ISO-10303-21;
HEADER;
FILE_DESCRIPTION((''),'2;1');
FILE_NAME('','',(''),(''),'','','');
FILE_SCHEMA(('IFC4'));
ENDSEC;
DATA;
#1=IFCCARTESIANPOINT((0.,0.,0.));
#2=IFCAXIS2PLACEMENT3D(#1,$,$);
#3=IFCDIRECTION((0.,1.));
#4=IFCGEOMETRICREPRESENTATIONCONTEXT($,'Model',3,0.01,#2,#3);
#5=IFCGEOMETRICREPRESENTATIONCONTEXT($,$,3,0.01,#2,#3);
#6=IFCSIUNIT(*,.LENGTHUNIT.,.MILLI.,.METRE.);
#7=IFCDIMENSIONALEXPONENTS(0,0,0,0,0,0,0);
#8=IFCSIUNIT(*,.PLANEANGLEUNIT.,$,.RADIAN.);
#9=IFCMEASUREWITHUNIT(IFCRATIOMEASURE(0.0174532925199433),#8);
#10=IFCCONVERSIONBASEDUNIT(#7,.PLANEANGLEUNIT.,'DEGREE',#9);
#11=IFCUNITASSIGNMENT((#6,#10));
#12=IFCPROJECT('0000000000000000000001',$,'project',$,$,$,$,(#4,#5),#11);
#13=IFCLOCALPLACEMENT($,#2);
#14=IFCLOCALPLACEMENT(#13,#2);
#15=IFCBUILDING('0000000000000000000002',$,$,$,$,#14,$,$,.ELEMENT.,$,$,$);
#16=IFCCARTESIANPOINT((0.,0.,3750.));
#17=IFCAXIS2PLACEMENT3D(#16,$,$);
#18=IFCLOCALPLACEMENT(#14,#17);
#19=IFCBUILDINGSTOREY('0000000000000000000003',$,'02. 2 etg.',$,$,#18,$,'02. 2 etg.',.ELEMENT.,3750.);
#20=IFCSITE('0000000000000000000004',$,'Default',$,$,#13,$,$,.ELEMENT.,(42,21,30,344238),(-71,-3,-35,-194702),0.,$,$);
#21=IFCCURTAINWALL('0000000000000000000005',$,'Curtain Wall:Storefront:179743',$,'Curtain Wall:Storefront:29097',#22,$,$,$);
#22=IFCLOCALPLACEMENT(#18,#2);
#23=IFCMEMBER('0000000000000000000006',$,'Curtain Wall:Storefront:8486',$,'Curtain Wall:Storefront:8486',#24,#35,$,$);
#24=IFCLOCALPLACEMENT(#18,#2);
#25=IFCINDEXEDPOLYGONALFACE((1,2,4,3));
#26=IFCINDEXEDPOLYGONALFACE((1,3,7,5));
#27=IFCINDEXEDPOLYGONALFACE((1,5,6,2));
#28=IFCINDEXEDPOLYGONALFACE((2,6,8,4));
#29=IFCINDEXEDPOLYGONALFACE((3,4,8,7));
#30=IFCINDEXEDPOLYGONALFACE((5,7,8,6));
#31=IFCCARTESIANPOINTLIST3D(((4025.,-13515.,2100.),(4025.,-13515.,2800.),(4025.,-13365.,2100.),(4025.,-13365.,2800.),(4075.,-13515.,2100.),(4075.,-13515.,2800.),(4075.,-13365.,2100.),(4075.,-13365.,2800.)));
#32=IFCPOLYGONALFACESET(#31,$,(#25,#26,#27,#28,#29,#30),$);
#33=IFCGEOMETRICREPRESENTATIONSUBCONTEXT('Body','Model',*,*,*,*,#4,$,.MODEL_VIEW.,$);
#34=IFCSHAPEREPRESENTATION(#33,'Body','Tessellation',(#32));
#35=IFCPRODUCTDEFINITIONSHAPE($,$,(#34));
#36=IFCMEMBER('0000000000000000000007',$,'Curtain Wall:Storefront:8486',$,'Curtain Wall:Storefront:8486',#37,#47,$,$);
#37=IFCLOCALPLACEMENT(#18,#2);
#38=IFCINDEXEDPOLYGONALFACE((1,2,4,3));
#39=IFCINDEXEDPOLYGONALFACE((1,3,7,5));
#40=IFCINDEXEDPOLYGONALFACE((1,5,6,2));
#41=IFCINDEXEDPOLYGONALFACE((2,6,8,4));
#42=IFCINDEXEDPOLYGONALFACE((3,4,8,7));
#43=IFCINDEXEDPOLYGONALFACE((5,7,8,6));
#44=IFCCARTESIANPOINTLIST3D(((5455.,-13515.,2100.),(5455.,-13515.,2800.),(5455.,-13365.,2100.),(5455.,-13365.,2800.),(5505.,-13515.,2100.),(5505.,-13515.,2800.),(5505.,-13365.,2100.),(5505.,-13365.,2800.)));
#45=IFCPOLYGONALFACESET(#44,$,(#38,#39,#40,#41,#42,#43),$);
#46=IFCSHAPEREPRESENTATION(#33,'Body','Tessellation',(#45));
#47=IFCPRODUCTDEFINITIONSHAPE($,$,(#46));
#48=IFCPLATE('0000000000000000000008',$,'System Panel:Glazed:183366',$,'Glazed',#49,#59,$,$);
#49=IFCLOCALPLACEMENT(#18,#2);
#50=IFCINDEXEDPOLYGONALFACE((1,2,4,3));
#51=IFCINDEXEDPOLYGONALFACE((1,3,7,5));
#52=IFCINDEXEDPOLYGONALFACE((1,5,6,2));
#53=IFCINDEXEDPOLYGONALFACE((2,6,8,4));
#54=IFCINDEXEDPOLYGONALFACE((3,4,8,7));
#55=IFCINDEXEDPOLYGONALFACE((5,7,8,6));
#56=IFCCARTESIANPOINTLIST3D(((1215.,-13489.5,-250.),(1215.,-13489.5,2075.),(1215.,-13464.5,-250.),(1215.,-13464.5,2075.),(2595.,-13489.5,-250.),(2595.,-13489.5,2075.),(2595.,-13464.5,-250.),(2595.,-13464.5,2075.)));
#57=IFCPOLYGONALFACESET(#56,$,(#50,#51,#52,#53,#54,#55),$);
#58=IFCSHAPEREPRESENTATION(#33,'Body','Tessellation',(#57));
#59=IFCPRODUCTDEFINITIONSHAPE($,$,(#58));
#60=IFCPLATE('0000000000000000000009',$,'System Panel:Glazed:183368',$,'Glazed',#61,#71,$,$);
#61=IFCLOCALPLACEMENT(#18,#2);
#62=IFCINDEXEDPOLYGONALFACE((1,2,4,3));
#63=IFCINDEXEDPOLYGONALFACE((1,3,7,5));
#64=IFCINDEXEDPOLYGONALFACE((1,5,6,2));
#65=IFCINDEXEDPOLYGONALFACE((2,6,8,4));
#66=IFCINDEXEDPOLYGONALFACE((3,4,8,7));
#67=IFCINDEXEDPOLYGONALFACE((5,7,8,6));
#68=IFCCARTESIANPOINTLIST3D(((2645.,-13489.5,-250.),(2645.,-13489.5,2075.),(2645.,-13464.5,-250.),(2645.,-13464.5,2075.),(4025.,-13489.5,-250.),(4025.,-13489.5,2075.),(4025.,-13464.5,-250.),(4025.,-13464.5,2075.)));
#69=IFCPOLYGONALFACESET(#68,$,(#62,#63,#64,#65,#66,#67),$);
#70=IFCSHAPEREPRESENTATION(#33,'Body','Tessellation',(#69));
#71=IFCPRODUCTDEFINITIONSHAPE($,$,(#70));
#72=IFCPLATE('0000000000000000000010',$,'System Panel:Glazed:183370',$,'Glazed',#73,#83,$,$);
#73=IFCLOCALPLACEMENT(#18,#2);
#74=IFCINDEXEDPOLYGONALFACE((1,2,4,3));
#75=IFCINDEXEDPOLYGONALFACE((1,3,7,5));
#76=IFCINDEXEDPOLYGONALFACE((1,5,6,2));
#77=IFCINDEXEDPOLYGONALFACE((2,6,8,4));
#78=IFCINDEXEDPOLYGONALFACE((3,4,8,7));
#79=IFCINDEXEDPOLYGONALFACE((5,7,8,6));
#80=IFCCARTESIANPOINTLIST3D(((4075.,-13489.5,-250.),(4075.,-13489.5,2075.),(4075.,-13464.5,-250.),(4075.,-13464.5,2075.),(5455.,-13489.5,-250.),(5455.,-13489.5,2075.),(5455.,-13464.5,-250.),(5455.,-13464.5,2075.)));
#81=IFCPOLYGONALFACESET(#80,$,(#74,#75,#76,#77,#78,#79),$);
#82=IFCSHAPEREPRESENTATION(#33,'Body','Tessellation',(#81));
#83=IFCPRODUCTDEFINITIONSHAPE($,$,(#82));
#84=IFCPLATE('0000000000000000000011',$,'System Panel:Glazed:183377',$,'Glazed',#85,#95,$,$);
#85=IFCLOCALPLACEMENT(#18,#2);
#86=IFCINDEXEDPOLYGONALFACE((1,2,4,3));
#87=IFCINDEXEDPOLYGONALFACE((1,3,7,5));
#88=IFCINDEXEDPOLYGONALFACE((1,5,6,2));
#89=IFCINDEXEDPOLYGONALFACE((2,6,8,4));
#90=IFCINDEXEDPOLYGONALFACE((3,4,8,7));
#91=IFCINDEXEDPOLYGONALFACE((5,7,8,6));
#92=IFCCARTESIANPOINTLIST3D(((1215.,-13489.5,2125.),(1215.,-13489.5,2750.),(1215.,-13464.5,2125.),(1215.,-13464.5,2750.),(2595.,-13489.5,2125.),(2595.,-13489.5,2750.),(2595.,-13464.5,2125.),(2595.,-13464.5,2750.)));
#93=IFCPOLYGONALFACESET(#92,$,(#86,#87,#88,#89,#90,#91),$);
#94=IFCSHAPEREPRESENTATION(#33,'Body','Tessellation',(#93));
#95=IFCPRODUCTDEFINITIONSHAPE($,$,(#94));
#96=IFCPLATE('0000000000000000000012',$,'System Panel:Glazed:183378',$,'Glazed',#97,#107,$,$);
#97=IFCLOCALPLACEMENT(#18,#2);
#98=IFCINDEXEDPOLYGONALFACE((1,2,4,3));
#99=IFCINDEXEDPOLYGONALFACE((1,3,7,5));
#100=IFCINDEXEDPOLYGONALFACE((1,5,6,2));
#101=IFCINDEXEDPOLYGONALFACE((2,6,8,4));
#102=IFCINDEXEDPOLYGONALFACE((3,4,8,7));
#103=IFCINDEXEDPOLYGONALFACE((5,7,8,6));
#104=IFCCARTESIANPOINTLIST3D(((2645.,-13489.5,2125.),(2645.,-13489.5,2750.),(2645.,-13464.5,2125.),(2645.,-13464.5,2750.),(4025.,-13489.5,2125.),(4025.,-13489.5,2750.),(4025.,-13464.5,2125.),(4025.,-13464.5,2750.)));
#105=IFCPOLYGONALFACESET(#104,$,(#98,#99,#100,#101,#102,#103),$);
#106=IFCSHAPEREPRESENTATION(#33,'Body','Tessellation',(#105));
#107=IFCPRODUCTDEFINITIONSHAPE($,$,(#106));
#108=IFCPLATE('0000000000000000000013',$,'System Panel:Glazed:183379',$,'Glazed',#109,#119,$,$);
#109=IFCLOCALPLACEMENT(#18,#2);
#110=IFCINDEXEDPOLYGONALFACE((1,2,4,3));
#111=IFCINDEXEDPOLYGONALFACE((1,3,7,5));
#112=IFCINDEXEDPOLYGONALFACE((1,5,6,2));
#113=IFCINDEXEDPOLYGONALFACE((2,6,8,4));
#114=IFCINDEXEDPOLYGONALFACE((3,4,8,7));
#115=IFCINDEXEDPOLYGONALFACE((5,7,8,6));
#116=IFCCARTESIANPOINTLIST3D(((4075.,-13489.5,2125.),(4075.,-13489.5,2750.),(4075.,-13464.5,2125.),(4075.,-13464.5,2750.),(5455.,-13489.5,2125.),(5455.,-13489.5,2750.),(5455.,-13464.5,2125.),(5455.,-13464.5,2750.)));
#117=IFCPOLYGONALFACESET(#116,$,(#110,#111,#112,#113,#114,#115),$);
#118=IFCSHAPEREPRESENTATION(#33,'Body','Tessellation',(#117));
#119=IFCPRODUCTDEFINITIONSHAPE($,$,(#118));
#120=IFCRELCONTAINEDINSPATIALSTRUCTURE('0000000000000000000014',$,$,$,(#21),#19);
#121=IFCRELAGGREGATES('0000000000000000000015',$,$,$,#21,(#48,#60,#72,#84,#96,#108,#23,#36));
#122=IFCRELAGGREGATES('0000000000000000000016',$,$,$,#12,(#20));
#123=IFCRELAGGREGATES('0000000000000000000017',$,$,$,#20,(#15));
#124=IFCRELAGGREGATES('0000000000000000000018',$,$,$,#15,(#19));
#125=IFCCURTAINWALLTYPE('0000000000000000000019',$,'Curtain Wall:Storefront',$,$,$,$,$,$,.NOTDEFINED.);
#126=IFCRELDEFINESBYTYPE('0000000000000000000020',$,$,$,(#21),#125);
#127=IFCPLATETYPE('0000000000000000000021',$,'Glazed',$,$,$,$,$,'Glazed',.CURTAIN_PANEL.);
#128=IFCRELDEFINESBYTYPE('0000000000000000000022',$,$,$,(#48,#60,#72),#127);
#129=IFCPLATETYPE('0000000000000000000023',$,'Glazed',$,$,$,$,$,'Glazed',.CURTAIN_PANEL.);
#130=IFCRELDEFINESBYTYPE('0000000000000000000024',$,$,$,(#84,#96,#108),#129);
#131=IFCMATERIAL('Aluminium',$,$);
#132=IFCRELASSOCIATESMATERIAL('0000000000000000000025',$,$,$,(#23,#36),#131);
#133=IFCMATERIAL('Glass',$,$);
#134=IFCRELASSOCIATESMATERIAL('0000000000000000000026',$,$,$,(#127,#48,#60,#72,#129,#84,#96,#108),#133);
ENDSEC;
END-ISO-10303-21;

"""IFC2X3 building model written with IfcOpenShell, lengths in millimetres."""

from ifc_helpers import new_model, entity, si_unit, converted_unit, direction, frame, frame_2d, origin, place, context, subcontext, project, spatial, rectangle, extrude, source, transform, mapped, material, type_object, type_shapes, element, aggregate, save


model = new_model("IFC2X3")

# Units and contexts
model_context = context("Model", 3, precision=0.01, world=origin(), true_north=direction((0.0, 1.0)))
context_of_model = context(None, 3, precision=0.01, world=origin(), true_north=direction((0.0, 1.0)))
body_context = subcontext(model_context, "Body", "Model", "MODEL_VIEW")
ifc_project = project(units=[si_unit("LENGTHUNIT", "METRE", prefix="MILLI"), converted_unit("PLANEANGLEUNIT", "DEGREE", entity("IfcRatioMeasure", 0.0174532925199433), si_unit("PLANEANGLEUNIT", "RADIAN"), dimensions=[0, 0, 0, 0, 0, 0, 0])], contexts=[model_context, context_of_model])

# Site, building, storey
site_placement = place(None, origin())
site = spatial("IfcSite", under=ifc_project, at=site_placement, Name="Default", CompositionType="ELEMENT", RefLatitude=(42, 21, 30, 344238), RefLongitude=(-71, -3, -35, -194702), RefElevation=0.0)
building_placement = place(site_placement, origin())
building = spatial("IfcBuilding", under=site, at=building_placement, CompositionType="ELEMENT")
storey_placement = place(building_placement, frame((0.0, 0.0, 3750.0)))
storey = spatial("IfcBuildingStorey", under=building, at=storey_placement, Name="02. 2 etg.", LongName="02. 2 etg.", CompositionType="ELEMENT", Elevation=3750.0)

# Curtain wall, members, plates
curtain_wall_type = type_object("IfcCurtainWallType", Name="Curtain Wall:Storefront", PredefinedType="NOTDEFINED")
curtain_wall_placement = place(storey_placement, frame((0.0, 0.0, -3750.0)))
curtain_wall = element("IfcCurtainWall", 1, at=curtain_wall_placement, inside=storey, type_object=curtain_wall_type, Name="Curtain Wall:Storefront:179743", ObjectType="Curtain Wall:Storefront:29097")
ifc_material_1 = material(Name="Aluminium")
member_1_placement = place(curtain_wall_placement, frame((4025.0, -13515.0, 5850.0)))
member_1 = element("IfcMember", 2, at=member_1_placement, material=ifc_material_1, Name="Curtain Wall:Storefront:8486", ObjectType="Curtain Wall:Storefront:8486", context=body_context, shape_type="SweptSolid", body=[
    extrude(rectangle(XDim=150.0, YDim=50.0, at=frame_2d((0.0, 0.0), x_axis=(1.0, 0.0))), frame((25.0, 75.0, 0.0), z_axis=(0.0, 0.0, 1.0), x_axis=(0.0, 1.0, 0.0)), (0.0, 0.0, 1.0), 700.0),
])
member_2_placement = place(curtain_wall_placement, frame((5455.0, -13515.0, 5850.0)))
member_2 = element("IfcMember", 3, at=member_2_placement, material=ifc_material_1, Name="Curtain Wall:Storefront:8486", ObjectType="Curtain Wall:Storefront:8486", context=body_context, shape_type="SweptSolid", body=[
    extrude(rectangle(XDim=150.0, YDim=50.0, at=frame_2d((0.0, 0.0), x_axis=(1.0, 0.0))), frame((25.0, 75.0, 0.0), z_axis=(0.0, 0.0, 1.0), x_axis=(0.0, 1.0, 0.0)), (0.0, 0.0, 1.0), 700.0),
])
ifc_material_2 = material(Name="Glass")
plate_type_1 = type_object("IfcPlateType", Name="Glazed", ElementType="Glazed", PredefinedType="CURTAIN_PANEL", material=ifc_material_2)
shared_shape_1 = source(origin(), body_context, "Body", "SweptSolid", [
    extrude(rectangle(XDim=25.0, YDim=1380.0, at=frame_2d((0.0, 0.0), x_axis=(1.0, 0.0))), frame((690.0, 12.5, 0.0), z_axis=(0.0, 0.0, 1.0), x_axis=(0.0, 1.0, 0.0)), (0.0, 0.0, 1.0), 2325.0),
])
type_shapes(plate_type_1, [shared_shape_1])
plate_1_placement = place(curtain_wall_placement, frame((1215.0, -13489.5, 3500.0)))
plate_1 = element("IfcPlate", 4, at=plate_1_placement, type_object=plate_type_1, material=ifc_material_2, Name="System Panel:Glazed:183366", ObjectType="Glazed", context=body_context, shape_type="MappedRepresentation", body=[
    mapped(shared_shape_1, transform((0.0, 0.0, 0.0), scale=1.0)),
])
plate_2_placement = place(curtain_wall_placement, frame((2645.0, -13489.5, 3500.0)))
plate_2 = element("IfcPlate", 5, at=plate_2_placement, type_object=plate_type_1, material=ifc_material_2, Name="System Panel:Glazed:183368", ObjectType="Glazed", context=body_context, shape_type="MappedRepresentation", body=[
    mapped(shared_shape_1, transform((0.0, 0.0, 0.0), scale=1.0)),
])
plate_3_placement = place(curtain_wall_placement, frame((4075.0, -13489.5, 3500.0)))
plate_3 = element("IfcPlate", 6, at=plate_3_placement, type_object=plate_type_1, material=ifc_material_2, Name="System Panel:Glazed:183370", ObjectType="Glazed", context=body_context, shape_type="MappedRepresentation", body=[
    mapped(shared_shape_1, transform((0.0, 0.0, 0.0), scale=1.0)),
])
plate_type_2 = type_object("IfcPlateType", Name="Glazed", ElementType="Glazed", PredefinedType="CURTAIN_PANEL", material=ifc_material_2)
shared_shape_2 = source(origin(), body_context, "Body", "SweptSolid", [
    extrude(rectangle(XDim=25.0, YDim=1380.0, at=frame_2d((0.0, 0.0), x_axis=(1.0, 0.0))), frame((690.0, 12.5, 0.0), z_axis=(0.0, 0.0, 1.0), x_axis=(0.0, 1.0, 0.0)), (0.0, 0.0, 1.0), 625.0),
])
type_shapes(plate_type_2, [shared_shape_2])
plate_4_placement = place(curtain_wall_placement, frame((1215.0, -13489.5, 5875.0)))
plate_4 = element("IfcPlate", 7, at=plate_4_placement, type_object=plate_type_2, material=ifc_material_2, Name="System Panel:Glazed:183377", ObjectType="Glazed", context=body_context, shape_type="MappedRepresentation", body=[
    mapped(shared_shape_2, transform((0.0, 0.0, 0.0), scale=1.0)),
])
plate_5_placement = place(curtain_wall_placement, frame((2645.0, -13489.5, 5875.0)))
plate_5 = element("IfcPlate", 8, at=plate_5_placement, type_object=plate_type_2, material=ifc_material_2, Name="System Panel:Glazed:183378", ObjectType="Glazed", context=body_context, shape_type="MappedRepresentation", body=[
    mapped(shared_shape_2, transform((0.0, 0.0, 0.0), scale=1.0)),
])
plate_6_placement = place(curtain_wall_placement, frame((4075.0, -13489.5, 5875.0)))
plate_6 = element("IfcPlate", 9, at=plate_6_placement, type_object=plate_type_2, material=ifc_material_2, Name="System Panel:Glazed:183379", ObjectType="Glazed", context=body_context, shape_type="MappedRepresentation", body=[
    mapped(shared_shape_2, transform((0.0, 0.0, 0.0), scale=1.0)),
])
aggregate(curtain_wall, [plate_1, plate_2, plate_3, plate_4, plate_5, plate_6, member_1, member_2])

save(model, "model.ifc")
